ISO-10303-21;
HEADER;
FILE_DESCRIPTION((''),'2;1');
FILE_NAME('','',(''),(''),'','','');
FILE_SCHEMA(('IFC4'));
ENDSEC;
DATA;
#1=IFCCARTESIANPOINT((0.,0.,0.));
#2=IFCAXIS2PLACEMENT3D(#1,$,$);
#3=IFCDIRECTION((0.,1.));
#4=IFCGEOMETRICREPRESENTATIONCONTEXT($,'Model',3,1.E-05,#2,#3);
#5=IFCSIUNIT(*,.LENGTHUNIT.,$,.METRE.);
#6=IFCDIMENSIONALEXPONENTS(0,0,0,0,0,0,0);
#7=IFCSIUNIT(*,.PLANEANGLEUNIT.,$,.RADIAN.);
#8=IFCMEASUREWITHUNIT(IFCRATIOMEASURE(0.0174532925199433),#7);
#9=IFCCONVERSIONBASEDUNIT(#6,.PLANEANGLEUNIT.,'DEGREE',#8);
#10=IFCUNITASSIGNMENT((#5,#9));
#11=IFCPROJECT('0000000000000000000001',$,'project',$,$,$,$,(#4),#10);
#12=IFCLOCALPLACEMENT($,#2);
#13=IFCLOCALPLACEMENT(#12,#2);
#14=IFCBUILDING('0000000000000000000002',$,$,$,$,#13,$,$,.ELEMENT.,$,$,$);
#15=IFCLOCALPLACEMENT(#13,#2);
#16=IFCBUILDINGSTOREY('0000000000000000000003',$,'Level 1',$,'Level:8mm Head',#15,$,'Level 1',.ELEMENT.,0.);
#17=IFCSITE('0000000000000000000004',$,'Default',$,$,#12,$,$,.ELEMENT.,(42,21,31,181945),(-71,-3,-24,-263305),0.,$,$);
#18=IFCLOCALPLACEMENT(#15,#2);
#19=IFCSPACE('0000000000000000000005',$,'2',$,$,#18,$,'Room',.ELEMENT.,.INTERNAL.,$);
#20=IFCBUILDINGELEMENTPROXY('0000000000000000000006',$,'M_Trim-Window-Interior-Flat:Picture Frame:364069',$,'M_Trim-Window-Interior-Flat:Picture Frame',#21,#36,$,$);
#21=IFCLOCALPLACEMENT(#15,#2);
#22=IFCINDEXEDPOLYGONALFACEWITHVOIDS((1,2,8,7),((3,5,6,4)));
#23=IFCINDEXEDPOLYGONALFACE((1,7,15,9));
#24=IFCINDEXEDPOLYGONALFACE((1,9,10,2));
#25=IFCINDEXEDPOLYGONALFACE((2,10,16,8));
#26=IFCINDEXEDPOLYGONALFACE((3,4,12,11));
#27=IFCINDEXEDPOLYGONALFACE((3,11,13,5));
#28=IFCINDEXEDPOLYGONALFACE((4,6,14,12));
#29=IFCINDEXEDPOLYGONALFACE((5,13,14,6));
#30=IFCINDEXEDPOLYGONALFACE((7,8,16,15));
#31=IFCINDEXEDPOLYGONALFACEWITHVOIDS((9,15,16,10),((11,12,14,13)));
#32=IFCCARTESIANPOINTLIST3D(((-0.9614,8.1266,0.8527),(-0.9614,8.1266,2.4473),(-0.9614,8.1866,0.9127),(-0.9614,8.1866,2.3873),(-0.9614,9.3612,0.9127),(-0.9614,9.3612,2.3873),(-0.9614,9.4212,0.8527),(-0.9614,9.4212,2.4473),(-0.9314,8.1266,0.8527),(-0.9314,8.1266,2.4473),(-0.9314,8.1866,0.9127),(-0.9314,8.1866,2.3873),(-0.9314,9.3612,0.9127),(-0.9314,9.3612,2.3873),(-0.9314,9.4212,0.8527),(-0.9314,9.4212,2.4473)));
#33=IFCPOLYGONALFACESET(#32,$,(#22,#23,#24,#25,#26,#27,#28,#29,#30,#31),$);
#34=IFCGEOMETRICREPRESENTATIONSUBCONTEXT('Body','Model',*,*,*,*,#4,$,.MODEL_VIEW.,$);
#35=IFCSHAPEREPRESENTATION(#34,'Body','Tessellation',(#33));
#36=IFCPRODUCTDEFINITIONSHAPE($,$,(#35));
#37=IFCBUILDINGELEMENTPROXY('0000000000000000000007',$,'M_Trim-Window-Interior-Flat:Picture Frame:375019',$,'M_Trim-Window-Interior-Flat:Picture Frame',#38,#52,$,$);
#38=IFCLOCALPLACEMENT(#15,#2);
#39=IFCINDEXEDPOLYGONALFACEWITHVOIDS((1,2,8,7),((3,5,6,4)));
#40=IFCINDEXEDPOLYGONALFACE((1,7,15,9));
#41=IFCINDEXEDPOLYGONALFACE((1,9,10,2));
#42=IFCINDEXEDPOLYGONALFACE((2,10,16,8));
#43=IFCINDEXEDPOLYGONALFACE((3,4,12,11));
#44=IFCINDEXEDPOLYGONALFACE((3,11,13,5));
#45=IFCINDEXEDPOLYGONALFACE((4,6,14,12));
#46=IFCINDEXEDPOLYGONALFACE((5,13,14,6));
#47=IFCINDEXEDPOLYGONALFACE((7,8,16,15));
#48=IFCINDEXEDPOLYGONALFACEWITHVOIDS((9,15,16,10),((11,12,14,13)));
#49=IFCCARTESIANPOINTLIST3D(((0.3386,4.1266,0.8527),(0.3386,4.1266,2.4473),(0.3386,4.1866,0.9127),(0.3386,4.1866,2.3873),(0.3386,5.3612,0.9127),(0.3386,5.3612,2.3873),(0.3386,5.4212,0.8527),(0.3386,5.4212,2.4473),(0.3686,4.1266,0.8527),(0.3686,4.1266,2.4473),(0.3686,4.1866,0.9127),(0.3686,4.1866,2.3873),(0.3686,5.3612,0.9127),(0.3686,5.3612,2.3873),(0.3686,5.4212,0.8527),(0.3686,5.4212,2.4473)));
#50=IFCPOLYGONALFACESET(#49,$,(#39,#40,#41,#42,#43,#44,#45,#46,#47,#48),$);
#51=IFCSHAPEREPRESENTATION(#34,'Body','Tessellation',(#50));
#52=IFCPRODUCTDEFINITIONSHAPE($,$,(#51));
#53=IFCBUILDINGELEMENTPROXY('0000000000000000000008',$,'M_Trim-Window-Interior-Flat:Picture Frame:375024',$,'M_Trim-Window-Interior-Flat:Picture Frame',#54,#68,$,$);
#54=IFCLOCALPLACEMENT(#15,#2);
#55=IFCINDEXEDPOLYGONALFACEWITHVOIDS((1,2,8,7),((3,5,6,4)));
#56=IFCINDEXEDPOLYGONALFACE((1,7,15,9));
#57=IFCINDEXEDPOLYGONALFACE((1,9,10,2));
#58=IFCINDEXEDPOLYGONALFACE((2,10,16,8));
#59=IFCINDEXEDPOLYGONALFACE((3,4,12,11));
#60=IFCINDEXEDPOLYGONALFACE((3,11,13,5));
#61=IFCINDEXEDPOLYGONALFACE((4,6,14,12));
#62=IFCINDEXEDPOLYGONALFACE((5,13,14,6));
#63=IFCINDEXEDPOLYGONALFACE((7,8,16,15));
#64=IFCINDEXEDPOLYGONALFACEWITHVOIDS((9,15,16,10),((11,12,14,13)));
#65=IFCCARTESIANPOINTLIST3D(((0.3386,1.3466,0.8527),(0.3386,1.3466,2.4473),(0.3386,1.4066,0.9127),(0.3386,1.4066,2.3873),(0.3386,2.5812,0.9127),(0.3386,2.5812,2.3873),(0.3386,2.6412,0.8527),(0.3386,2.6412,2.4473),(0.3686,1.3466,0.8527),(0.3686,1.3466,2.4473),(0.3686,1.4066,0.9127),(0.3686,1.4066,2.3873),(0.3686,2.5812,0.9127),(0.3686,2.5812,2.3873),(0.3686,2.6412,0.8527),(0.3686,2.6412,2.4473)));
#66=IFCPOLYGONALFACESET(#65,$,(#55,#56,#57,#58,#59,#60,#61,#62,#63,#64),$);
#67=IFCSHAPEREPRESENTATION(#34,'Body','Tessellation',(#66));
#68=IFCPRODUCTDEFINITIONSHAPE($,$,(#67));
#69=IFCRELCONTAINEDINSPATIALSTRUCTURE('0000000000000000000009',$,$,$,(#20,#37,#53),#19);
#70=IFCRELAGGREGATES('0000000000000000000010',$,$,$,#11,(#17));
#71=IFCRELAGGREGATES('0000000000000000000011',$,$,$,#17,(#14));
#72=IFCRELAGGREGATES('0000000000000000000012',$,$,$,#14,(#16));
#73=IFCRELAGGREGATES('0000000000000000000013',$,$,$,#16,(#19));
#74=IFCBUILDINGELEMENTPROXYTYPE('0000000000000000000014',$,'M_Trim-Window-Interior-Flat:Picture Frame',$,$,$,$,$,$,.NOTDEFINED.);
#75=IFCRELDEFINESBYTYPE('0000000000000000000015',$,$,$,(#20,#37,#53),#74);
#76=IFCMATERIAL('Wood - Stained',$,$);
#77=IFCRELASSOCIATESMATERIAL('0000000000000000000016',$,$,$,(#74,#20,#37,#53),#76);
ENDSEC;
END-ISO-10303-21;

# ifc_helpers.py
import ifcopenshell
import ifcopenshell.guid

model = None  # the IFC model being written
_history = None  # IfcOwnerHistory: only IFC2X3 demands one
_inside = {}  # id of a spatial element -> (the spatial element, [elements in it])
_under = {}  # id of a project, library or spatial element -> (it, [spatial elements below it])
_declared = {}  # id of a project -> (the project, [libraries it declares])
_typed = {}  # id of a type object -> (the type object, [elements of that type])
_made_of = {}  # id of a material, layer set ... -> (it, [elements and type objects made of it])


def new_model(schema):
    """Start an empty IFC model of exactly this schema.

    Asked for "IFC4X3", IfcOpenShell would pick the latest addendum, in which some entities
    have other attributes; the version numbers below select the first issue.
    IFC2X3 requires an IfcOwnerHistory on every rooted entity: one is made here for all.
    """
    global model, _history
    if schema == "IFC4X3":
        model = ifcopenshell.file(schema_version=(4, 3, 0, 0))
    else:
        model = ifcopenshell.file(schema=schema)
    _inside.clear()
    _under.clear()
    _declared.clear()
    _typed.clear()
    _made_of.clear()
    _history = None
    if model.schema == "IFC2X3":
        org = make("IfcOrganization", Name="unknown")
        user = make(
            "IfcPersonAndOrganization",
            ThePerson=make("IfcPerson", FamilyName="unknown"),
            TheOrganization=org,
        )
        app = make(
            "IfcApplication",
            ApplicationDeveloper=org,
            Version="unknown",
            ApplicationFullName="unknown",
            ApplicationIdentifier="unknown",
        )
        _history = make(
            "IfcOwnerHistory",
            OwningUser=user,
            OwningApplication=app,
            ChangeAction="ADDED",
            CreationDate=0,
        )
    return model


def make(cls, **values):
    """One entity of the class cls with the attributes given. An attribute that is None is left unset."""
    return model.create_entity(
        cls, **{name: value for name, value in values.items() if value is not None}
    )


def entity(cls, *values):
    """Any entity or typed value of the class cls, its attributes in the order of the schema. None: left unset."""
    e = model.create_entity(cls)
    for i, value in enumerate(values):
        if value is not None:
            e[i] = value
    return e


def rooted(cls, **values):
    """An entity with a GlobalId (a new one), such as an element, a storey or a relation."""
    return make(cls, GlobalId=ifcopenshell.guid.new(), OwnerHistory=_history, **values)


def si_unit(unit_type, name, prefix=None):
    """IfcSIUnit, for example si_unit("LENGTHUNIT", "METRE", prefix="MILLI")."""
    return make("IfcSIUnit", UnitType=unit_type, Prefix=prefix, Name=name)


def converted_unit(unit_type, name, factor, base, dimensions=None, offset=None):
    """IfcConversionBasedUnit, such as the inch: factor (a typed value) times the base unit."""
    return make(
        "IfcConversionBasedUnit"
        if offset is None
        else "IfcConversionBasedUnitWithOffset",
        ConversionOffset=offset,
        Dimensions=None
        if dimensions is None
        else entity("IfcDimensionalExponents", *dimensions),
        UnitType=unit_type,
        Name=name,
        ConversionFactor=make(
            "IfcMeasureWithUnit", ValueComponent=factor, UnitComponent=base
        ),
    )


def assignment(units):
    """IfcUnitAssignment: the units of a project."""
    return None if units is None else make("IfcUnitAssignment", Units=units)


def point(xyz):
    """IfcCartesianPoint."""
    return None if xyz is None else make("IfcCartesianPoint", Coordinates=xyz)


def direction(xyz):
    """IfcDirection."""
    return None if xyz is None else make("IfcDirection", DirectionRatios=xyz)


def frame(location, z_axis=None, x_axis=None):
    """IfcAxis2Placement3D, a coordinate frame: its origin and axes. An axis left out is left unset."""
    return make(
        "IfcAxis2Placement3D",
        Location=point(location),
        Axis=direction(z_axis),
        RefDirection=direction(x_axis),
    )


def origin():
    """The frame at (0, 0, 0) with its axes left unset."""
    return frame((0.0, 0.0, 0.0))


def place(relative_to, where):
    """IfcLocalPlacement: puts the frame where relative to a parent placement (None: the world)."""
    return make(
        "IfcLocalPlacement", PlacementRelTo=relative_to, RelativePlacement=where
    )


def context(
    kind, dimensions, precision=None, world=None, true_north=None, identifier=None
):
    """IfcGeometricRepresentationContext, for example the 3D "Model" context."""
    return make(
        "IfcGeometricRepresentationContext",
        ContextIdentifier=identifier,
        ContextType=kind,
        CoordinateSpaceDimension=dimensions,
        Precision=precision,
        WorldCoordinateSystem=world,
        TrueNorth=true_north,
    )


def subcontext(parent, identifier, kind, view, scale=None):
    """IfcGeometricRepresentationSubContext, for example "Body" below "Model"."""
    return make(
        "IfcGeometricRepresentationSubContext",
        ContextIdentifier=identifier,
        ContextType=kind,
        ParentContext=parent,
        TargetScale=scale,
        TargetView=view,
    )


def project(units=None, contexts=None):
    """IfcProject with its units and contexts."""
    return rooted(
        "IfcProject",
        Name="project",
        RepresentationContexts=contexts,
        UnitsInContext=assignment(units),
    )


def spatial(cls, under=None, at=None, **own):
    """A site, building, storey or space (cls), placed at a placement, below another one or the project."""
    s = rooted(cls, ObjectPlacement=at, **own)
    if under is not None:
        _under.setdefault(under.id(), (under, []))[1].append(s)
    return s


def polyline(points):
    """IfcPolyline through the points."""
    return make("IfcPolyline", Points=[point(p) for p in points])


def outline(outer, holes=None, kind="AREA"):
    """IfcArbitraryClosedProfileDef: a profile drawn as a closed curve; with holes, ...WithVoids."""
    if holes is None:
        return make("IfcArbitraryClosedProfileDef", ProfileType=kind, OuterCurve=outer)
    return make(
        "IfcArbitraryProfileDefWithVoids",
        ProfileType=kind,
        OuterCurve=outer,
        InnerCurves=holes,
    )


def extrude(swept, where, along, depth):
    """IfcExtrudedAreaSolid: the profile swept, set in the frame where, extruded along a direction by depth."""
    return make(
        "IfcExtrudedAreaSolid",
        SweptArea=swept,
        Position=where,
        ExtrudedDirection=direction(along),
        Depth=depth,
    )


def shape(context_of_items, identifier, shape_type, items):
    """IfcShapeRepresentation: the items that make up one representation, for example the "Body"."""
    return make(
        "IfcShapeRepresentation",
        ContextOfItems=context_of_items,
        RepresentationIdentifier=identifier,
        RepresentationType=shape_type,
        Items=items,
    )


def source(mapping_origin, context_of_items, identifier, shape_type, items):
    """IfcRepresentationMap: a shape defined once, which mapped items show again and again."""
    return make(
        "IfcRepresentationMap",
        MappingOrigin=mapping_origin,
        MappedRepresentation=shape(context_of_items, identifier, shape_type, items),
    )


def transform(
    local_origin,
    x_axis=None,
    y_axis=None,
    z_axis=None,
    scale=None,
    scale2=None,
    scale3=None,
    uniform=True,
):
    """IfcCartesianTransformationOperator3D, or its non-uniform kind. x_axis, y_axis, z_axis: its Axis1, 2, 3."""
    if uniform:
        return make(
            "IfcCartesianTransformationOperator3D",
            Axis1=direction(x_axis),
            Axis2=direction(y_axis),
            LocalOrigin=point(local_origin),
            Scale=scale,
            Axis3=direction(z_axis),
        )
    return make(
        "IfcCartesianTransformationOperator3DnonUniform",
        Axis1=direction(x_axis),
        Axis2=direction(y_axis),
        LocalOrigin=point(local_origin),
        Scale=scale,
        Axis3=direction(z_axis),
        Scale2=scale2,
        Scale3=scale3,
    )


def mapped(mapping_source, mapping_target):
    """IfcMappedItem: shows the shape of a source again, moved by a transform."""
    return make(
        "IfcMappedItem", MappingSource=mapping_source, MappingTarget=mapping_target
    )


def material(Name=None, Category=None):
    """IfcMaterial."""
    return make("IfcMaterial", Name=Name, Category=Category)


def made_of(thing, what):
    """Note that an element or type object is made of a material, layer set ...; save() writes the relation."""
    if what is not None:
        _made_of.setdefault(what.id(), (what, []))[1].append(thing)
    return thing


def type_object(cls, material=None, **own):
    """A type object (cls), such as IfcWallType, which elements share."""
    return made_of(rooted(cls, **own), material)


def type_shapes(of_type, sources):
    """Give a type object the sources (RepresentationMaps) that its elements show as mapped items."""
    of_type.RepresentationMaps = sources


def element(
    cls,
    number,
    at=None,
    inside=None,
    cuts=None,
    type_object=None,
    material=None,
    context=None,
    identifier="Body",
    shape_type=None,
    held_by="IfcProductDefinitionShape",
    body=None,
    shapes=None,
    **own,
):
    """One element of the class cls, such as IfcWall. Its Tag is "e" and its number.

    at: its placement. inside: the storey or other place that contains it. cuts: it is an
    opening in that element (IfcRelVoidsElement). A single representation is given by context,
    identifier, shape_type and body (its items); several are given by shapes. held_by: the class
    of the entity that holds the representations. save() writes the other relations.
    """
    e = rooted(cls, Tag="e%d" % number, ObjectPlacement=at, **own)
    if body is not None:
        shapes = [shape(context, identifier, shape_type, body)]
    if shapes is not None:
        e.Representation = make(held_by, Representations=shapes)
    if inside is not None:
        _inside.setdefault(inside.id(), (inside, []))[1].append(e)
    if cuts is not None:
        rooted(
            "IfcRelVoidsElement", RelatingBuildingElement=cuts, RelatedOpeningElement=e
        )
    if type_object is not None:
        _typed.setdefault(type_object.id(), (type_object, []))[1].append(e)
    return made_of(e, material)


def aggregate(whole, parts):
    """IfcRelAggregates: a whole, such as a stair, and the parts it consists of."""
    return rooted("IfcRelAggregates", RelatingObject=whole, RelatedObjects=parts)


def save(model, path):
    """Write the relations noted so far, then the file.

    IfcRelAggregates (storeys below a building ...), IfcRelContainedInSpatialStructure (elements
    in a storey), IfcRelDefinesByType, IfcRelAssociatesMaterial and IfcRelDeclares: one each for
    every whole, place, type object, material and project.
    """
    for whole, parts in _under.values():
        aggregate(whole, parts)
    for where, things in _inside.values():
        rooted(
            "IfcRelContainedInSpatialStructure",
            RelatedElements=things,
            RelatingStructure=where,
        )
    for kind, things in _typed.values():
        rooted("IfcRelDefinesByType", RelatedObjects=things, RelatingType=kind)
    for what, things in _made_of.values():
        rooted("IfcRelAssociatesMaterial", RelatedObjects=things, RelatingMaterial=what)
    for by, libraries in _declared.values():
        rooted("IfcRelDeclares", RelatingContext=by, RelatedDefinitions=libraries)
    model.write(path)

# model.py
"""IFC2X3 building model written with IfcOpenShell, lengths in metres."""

from ifc_helpers import new_model, entity, si_unit, converted_unit, direction, frame, origin, place, context, subcontext, project, spatial, polyline, outline, extrude, source, transform, mapped, material, type_object, type_shapes, element, save


model = new_model("IFC2X3")

# Units and contexts
model_context = context("Model", 3, precision=1e-05, world=origin(), true_north=direction((0.0, 1.0)))
body_context = subcontext(model_context, "Body", "Model", "MODEL_VIEW")
ifc_project = project(units=[si_unit("LENGTHUNIT", "METRE"), converted_unit("PLANEANGLEUNIT", "DEGREE", entity("IfcRatioMeasure", 0.0174532925199433), si_unit("PLANEANGLEUNIT", "RADIAN"), dimensions=[0, 0, 0, 0, 0, 0, 0])], contexts=[model_context])

# Site, building, storey
site_placement = place(None, origin())
site = spatial("IfcSite", under=ifc_project, at=site_placement, Name="Default", CompositionType="ELEMENT", RefLatitude=(42, 21, 31, 181945), RefLongitude=(-71, -3, -24, -263305), RefElevation=0.0)
building_placement = place(site_placement, origin())
building = spatial("IfcBuilding", under=site, at=building_placement, CompositionType="ELEMENT")
storey_placement = place(building_placement, origin())
storey = spatial("IfcBuildingStorey", under=building, at=storey_placement, Name="Level 1", ObjectType="Level:8mm Head", LongName="Level 1", CompositionType="ELEMENT", Elevation=0.0)

# Shared definitions
ifc_material_1 = material(Name="Wood - Stained")

# Shared definitions
space_placement = place(storey_placement, origin())
space = spatial("IfcSpace", under=storey, at=space_placement, Name="2", LongName="Room", CompositionType="ELEMENT", InteriorOrExteriorSpace="INTERNAL")

# Building element proxies
building_element_proxy_type_1 = type_object("IfcBuildingElementProxyType", Name="M_Trim-Window-Interior-Flat:Picture Frame", PredefinedType="NOTDEFINED", material=ifc_material_1)
shared_shape_1 = source(origin(), body_context, "Body", "SweptSolid", [
    extrude(outline(polyline([(-0.6473, -0.7973), (0.6473, -0.7973), (0.6473, 0.7973), (-0.6473, 0.7973), (-0.6473, -0.7973)]), holes=[polyline([(-0.5873, -0.7373), (-0.5873, 0.7373), (0.5873, 0.7373), (0.5873, -0.7373), (-0.5873, -0.7373)])]), frame((0.0, -0.75, 0.0), z_axis=(0.0, 0.0, 1.0), x_axis=(-1.0, 0.0, 0.0)), (0.0, 0.0, 1.0), 0.03),
])
type_shapes(building_element_proxy_type_1, [shared_shape_1])
for number, where, z_axis, x_axis, name in (
    (1, (-0.9314, 8.7739, 2.4), (-1.0, 0.0, 0.0), (0.0, -1.0, 0.0), "M_Trim-Window-Interior-Flat:Picture Frame:364069"),
    (2, (0.3686, 4.7739, 2.4), (-1.0, 0.0, 0.0), (0.0, -1.0, 0.0), "M_Trim-Window-Interior-Flat:Picture Frame:375019"),
    (3, (0.3686, 1.9939, 2.4), (-1.0, 0.0, 0.0), (0.0, -1.0, 0.0), "M_Trim-Window-Interior-Flat:Picture Frame:375024"),
):
    element("IfcBuildingElementProxy", number, at=place(space_placement, frame(where, z_axis=z_axis, x_axis=x_axis)), inside=space, type_object=building_element_proxy_type_1, material=ifc_material_1, Name=name, ObjectType="M_Trim-Window-Interior-Flat:Picture Frame", context=body_context, shape_type="MappedRepresentation", body=[
        mapped(shared_shape_1, transform((0.0, 0.0, 0.0), scale=1.0)),
    ])

save(model, "model.ifc")
